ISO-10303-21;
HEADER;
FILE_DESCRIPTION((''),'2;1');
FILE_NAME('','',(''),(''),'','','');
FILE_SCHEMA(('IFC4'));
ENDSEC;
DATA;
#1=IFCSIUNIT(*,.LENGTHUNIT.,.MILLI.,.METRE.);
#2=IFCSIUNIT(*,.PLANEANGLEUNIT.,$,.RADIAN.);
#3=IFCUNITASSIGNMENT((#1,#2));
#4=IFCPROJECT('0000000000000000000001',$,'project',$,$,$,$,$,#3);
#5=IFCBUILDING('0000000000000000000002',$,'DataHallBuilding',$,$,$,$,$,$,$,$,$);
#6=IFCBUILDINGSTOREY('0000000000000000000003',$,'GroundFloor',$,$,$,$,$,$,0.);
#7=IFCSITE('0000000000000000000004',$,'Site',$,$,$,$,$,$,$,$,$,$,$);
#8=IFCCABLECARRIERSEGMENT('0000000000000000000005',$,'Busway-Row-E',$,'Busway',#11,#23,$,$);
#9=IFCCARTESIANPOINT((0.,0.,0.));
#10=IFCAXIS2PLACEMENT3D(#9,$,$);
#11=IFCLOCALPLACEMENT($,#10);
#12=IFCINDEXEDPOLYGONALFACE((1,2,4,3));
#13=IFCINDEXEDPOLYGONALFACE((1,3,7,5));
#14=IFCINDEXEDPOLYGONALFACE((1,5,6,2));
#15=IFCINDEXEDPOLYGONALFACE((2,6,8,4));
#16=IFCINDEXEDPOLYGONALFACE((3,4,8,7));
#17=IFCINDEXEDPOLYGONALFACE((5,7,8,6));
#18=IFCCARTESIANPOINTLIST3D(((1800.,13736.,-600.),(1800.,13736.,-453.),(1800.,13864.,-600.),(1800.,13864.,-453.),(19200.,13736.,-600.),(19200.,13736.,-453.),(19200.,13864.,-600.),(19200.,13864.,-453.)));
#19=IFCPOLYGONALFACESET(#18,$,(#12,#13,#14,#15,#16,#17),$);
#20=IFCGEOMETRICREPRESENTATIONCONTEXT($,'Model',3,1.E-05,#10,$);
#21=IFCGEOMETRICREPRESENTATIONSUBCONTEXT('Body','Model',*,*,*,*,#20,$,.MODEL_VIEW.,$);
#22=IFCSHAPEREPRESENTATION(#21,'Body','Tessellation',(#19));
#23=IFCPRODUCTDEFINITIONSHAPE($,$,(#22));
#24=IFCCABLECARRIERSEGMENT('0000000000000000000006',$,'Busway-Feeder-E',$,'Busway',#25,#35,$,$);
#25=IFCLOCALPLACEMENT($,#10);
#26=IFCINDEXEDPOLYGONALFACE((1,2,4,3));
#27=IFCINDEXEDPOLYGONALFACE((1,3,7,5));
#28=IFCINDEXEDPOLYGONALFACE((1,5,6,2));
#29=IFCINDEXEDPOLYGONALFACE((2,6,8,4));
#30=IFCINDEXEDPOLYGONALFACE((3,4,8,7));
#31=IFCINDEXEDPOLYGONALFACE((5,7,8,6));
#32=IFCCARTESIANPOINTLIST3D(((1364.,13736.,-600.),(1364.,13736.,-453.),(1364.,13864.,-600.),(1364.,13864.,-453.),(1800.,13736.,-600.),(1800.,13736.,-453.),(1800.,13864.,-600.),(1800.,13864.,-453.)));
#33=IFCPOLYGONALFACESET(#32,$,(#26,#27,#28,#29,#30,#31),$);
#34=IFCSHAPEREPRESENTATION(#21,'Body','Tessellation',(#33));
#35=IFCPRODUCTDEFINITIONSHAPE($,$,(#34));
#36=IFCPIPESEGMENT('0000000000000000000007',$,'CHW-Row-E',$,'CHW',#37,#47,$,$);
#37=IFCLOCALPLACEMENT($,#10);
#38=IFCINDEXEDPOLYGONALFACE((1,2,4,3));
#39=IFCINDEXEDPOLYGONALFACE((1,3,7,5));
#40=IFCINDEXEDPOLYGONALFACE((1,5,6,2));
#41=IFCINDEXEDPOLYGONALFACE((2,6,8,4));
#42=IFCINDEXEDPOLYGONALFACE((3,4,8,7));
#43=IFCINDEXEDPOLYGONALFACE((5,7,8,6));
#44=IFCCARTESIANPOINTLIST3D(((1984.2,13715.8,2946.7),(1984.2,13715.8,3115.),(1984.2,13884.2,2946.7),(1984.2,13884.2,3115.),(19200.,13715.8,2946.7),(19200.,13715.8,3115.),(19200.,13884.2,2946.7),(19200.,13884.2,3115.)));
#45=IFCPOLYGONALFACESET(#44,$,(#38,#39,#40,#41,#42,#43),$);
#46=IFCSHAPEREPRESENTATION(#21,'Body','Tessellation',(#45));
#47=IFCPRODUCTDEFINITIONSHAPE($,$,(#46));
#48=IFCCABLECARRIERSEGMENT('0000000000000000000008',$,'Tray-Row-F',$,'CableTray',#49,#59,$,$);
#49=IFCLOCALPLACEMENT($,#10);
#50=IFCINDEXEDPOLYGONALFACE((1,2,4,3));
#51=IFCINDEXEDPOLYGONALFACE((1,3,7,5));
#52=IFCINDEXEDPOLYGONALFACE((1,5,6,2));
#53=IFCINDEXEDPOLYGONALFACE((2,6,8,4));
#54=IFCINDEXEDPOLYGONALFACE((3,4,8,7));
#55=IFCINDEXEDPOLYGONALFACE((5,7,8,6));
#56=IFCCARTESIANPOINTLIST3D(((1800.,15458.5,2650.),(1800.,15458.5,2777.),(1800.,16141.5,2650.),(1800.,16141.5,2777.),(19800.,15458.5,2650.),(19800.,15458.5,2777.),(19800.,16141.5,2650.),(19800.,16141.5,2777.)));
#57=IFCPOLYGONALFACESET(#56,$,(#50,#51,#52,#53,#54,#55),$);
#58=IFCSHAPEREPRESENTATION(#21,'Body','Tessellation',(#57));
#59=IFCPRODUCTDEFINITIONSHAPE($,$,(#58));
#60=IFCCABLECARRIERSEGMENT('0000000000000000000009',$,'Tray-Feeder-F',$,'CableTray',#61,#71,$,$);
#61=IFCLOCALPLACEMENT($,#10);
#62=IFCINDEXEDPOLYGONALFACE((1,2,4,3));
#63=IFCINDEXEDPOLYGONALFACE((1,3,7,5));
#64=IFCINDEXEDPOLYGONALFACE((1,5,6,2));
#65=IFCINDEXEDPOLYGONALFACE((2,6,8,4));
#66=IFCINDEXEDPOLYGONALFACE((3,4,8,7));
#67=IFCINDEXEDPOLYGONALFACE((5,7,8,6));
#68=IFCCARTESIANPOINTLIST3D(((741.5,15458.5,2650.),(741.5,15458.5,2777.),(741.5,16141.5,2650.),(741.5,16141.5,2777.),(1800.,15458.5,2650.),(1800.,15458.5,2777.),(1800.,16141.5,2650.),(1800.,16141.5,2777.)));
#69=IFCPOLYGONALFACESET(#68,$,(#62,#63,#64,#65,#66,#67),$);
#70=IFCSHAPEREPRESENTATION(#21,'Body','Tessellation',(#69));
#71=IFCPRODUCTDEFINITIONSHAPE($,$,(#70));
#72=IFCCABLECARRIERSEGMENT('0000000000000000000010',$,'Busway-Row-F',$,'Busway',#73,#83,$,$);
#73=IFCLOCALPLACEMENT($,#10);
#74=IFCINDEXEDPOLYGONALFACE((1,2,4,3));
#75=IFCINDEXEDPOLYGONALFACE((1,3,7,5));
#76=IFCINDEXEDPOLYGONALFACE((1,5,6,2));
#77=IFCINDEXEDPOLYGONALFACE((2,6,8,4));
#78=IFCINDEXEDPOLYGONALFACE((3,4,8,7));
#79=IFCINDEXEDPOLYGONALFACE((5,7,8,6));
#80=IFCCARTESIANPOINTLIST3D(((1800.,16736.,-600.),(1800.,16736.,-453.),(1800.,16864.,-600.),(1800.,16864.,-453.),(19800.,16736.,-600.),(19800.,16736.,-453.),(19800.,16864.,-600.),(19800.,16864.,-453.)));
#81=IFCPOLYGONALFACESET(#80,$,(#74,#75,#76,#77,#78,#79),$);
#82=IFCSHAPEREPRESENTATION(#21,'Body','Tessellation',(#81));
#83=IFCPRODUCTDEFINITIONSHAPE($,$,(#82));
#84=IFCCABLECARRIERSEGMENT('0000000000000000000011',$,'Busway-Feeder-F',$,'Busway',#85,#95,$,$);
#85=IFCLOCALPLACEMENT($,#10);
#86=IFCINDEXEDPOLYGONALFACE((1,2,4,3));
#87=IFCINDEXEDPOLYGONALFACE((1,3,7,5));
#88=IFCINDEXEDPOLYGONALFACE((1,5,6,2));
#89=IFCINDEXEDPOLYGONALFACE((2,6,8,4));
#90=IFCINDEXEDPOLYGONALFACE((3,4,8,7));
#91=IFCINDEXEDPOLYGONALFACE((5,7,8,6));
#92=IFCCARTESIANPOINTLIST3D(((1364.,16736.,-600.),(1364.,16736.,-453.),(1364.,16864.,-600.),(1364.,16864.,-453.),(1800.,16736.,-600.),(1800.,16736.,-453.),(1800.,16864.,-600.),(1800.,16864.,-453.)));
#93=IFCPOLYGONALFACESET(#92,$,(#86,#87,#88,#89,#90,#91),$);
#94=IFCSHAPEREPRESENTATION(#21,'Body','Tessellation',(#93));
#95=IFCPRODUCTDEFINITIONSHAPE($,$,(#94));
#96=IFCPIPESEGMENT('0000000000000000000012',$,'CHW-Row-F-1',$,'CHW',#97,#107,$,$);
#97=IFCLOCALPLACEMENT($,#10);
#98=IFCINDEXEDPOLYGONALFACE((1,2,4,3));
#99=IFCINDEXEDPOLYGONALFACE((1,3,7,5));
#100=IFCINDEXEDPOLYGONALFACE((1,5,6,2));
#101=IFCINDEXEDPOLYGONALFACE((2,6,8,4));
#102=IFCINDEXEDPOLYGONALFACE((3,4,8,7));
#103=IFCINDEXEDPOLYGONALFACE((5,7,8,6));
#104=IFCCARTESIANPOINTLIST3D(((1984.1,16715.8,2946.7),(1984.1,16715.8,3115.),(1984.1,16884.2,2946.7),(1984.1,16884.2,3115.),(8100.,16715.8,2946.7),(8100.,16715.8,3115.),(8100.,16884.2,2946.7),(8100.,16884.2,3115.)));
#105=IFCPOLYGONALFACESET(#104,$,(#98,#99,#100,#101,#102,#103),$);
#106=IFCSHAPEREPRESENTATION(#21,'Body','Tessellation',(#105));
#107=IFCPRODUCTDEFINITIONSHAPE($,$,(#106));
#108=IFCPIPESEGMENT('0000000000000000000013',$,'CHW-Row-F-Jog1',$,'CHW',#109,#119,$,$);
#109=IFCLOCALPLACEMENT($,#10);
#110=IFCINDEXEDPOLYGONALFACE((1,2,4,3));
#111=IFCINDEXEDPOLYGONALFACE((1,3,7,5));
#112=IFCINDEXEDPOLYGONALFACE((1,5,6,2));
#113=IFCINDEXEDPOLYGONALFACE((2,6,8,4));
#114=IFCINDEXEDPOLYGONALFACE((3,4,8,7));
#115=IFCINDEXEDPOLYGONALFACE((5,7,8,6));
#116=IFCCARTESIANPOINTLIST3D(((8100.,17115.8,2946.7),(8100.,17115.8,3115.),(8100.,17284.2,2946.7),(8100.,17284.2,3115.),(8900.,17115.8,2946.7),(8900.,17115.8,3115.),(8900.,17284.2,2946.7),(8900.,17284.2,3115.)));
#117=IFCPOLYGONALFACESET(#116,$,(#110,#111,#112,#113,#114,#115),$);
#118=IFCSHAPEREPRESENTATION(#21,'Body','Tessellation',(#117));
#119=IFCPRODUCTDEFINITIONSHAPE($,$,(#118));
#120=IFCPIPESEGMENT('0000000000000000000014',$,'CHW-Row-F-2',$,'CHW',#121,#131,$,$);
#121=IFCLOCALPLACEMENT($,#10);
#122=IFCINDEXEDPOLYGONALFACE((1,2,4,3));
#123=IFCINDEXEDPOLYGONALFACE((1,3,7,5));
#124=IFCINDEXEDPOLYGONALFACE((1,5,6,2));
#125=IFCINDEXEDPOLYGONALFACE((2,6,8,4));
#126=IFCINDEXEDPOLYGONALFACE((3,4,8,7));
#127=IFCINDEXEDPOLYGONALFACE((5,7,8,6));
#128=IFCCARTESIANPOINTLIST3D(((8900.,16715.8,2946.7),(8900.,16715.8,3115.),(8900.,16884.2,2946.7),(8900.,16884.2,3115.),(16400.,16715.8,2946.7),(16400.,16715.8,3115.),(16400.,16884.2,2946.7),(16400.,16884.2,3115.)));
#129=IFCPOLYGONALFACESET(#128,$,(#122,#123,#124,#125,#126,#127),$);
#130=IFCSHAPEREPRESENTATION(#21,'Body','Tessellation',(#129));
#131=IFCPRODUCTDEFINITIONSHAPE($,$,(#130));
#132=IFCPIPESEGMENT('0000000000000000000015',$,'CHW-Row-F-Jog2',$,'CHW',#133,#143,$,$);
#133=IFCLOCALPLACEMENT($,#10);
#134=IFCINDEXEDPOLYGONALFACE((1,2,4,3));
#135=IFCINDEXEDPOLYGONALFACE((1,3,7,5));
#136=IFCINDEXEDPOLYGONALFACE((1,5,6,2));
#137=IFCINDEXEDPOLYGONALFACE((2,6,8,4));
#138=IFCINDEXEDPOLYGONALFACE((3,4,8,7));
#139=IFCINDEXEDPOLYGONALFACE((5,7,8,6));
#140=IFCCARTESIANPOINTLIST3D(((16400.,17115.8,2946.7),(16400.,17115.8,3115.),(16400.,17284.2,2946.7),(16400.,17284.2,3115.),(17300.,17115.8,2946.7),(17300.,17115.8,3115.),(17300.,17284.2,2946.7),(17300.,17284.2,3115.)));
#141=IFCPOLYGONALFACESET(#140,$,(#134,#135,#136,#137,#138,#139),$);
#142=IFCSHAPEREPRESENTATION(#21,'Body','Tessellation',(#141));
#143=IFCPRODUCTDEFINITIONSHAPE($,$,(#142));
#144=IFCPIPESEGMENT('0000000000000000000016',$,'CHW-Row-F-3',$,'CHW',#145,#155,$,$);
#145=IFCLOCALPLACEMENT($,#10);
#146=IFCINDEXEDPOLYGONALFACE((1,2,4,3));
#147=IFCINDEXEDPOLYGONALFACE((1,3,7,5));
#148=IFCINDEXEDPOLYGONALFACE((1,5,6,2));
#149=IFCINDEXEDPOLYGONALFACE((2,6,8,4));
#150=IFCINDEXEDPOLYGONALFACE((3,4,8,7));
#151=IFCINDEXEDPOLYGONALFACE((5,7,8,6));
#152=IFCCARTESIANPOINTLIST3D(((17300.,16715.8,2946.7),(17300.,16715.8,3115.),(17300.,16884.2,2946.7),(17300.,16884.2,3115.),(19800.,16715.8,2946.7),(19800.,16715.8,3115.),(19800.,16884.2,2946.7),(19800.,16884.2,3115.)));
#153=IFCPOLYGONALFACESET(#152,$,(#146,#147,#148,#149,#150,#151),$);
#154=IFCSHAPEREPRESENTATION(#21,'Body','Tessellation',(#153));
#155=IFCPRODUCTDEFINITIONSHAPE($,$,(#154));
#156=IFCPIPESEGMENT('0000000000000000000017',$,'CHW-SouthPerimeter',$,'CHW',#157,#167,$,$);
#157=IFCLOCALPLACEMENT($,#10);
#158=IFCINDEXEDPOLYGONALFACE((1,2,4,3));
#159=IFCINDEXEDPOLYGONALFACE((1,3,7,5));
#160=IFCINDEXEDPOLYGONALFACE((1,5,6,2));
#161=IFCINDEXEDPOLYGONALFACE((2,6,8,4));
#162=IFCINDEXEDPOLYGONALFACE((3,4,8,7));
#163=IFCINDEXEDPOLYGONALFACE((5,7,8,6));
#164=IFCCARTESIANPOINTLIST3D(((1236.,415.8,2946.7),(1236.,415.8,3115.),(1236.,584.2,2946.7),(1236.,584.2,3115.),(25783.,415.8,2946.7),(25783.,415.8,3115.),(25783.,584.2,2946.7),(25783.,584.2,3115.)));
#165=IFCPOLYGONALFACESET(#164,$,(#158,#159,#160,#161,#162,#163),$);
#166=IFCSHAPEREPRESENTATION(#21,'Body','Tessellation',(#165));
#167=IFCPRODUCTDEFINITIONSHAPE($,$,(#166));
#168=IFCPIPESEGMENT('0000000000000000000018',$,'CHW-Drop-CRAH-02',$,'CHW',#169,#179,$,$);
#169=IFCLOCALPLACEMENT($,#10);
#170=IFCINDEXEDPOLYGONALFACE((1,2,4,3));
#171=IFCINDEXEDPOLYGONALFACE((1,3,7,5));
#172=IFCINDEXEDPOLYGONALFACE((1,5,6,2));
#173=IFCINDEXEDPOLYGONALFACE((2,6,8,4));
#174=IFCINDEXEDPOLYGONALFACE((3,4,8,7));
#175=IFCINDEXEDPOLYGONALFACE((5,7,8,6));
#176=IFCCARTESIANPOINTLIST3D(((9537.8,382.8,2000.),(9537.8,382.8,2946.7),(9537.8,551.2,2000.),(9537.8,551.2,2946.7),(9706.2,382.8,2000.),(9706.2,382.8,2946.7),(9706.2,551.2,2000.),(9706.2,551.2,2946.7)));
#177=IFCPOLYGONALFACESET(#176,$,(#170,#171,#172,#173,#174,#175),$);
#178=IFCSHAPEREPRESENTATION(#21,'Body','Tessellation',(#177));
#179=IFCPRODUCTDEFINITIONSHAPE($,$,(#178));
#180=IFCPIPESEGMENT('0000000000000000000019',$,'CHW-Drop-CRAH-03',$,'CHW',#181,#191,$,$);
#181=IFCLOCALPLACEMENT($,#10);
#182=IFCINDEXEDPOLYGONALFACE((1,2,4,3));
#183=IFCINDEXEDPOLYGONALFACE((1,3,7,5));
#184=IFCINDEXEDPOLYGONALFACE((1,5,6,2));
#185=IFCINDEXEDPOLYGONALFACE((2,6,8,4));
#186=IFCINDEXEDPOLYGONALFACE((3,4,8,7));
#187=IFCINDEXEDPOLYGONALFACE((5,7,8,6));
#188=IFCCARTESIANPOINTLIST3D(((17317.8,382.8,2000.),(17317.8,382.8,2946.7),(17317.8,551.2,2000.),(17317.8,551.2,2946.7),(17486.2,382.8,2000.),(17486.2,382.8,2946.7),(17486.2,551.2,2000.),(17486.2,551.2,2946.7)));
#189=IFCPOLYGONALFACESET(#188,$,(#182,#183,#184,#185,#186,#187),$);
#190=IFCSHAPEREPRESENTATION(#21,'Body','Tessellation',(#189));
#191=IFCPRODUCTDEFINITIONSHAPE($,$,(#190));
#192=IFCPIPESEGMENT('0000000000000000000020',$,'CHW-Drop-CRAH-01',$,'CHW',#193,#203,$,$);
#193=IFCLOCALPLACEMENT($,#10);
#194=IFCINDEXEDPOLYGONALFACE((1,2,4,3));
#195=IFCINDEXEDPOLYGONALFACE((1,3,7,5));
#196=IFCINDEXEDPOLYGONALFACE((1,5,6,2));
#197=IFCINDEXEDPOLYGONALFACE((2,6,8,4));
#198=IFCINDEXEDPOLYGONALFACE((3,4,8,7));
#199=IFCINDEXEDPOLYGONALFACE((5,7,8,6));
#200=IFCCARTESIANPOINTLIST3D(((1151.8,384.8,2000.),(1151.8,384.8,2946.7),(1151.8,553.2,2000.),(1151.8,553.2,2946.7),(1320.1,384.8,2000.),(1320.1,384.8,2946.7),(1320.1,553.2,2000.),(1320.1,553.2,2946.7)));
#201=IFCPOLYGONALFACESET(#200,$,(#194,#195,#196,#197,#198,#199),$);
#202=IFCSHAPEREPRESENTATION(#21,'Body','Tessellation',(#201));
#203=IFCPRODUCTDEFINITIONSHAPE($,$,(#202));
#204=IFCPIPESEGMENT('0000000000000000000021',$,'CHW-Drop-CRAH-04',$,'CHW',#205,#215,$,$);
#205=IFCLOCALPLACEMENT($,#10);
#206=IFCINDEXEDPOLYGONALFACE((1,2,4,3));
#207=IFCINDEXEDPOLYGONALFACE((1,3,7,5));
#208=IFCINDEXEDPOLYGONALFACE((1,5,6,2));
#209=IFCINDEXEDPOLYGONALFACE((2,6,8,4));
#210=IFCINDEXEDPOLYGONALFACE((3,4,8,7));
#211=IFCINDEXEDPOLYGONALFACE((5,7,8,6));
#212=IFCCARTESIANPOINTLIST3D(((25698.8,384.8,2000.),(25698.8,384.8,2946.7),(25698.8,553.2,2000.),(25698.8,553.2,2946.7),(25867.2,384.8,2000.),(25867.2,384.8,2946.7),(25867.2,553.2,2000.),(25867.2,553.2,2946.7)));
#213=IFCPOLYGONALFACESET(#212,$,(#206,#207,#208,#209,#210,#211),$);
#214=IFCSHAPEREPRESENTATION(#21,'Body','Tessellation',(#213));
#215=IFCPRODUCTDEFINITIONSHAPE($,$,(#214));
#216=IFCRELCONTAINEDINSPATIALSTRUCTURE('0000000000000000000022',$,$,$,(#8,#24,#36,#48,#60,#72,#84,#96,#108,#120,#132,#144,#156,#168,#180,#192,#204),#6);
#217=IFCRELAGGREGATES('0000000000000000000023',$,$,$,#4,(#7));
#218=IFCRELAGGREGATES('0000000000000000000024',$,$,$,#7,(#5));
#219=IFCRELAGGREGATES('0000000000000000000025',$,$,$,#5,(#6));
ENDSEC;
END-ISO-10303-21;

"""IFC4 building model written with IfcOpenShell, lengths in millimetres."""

from ifc_helpers import new_model, si_unit, frame, origin, place, context, subcontext, project, spatial, rectangle, extrude, element, save


model = new_model("IFC4")

# Units and contexts
model_context = context("Model", 3, precision=1e-05, world=origin())
body_context = subcontext(model_context, "Body", "Model", "MODEL_VIEW")
ifc_project = project(units=[si_unit("LENGTHUNIT", "METRE", prefix="MILLI"), si_unit("PLANEANGLEUNIT", "RADIAN")])

# Site, building, storey
site = spatial("IfcSite", under=ifc_project, Name="Site")
building = spatial("IfcBuilding", under=site, Name="DataHallBuilding")
storey = spatial("IfcBuildingStorey", under=building, Name="GroundFloor", Elevation=0.0)

# Cable carrier segments
cable_carrier_segment_1_placement = place(None, origin())
element("IfcCableCarrierSegment", 1, at=cable_carrier_segment_1_placement, inside=storey, Name="Busway-Row-E", ObjectType="Busway", context=body_context, shape_type="SweptSolid", body=[
    extrude(rectangle(XDim=17400.0, YDim=128.0), frame((10500.0, 13800.0, -600.0), z_axis=(0.0, 0.0, 1.0), x_axis=(1.0, 0.0, 0.0)), (0.0, 0.0, 1.0), 147.0),
])
cable_carrier_segment_2_placement = place(None, origin())
element("IfcCableCarrierSegment", 2, at=cable_carrier_segment_2_placement, inside=storey, Name="Busway-Feeder-E", ObjectType="Busway", context=body_context, shape_type="SweptSolid", body=[
    extrude(rectangle(XDim=436.0, YDim=128.0), frame((1582.0, 13800.0, -600.0), z_axis=(0.0, 0.0, 1.0), x_axis=(1.0, 0.0, 0.0)), (0.0, 0.0, 1.0), 147.0),
])

# Pipe segment
pipe_segment_1_placement = place(None, origin())
element("IfcPipeSegment", 3, at=pipe_segment_1_placement, inside=storey, Name="CHW-Row-E", ObjectType="CHW", context=body_context, shape_type="SweptSolid", body=[
    extrude(rectangle(XDim=17215.8, YDim=168.3), frame((10592.1, 13800.0, 2946.7), z_axis=(0.0, 0.0, 1.0), x_axis=(1.0, 0.0, 0.0)), (0.0, 0.0, 1.0), 168.3),
])

# Cable carrier segments
cable_carrier_segment_3_placement = place(None, origin())
element("IfcCableCarrierSegment", 4, at=cable_carrier_segment_3_placement, inside=storey, Name="Tray-Row-F", ObjectType="CableTray", context=body_context, shape_type="SweptSolid", body=[
    extrude(rectangle(XDim=18000.0, YDim=683.0), frame((10800.0, 15800.0, 2650.0), z_axis=(0.0, 0.0, 1.0), x_axis=(1.0, 0.0, 0.0)), (0.0, 0.0, 1.0), 127.0),
])
cable_carrier_segment_4_placement = place(None, origin())
element("IfcCableCarrierSegment", 5, at=cable_carrier_segment_4_placement, inside=storey, Name="Tray-Feeder-F", ObjectType="CableTray", context=body_context, shape_type="SweptSolid", body=[
    extrude(rectangle(XDim=1058.5, YDim=683.0), frame((1270.8, 15800.0, 2650.0), z_axis=(0.0, 0.0, 1.0), x_axis=(1.0, 0.0, 0.0)), (0.0, 0.0, 1.0), 127.0),
])
cable_carrier_segment_5_placement = place(None, origin())
element("IfcCableCarrierSegment", 6, at=cable_carrier_segment_5_placement, inside=storey, Name="Busway-Row-F", ObjectType="Busway", context=body_context, shape_type="SweptSolid", body=[
    extrude(rectangle(XDim=18000.0, YDim=128.0), frame((10800.0, 16800.0, -600.0), z_axis=(0.0, 0.0, 1.0), x_axis=(1.0, 0.0, 0.0)), (0.0, 0.0, 1.0), 147.0),
])
cable_carrier_segment_6_placement = place(None, origin())
element("IfcCableCarrierSegment", 7, at=cable_carrier_segment_6_placement, inside=storey, Name="Busway-Feeder-F", ObjectType="Busway", context=body_context, shape_type="SweptSolid", body=[
    extrude(rectangle(XDim=436.0, YDim=128.0), frame((1582.0, 16800.0, -600.0), z_axis=(0.0, 0.0, 1.0), x_axis=(1.0, 0.0, 0.0)), (0.0, 0.0, 1.0), 147.0),
])

# Pipe segments
pipe_segment_2_placement = place(None, origin())
element("IfcPipeSegment", 8, at=pipe_segment_2_placement, inside=storey, Name="CHW-Row-F-1", ObjectType="CHW", context=body_context, shape_type="SweptSolid", body=[
    extrude(rectangle(XDim=6115.9, YDim=168.3), frame((5042.1, 16800.0, 2946.7), z_axis=(0.0, 0.0, 1.0), x_axis=(1.0, 0.0, 0.0)), (0.0, 0.0, 1.0), 168.3),
])
pipe_segment_3_placement = place(None, origin())
element("IfcPipeSegment", 9, at=pipe_segment_3_placement, inside=storey, Name="CHW-Row-F-Jog1", ObjectType="CHW", context=body_context, shape_type="SweptSolid", body=[
    extrude(rectangle(XDim=800.0, YDim=168.3), frame((8500.0, 17200.0, 2946.7), z_axis=(0.0, 0.0, 1.0), x_axis=(1.0, 0.0, 0.0)), (0.0, 0.0, 1.0), 168.3),
])
pipe_segment_4_placement = place(None, origin())
element("IfcPipeSegment", 10, at=pipe_segment_4_placement, inside=storey, Name="CHW-Row-F-2", ObjectType="CHW", context=body_context, shape_type="SweptSolid", body=[
    extrude(rectangle(XDim=7500.0, YDim=168.3), frame((12650.0, 16800.0, 2946.7), z_axis=(0.0, 0.0, 1.0), x_axis=(1.0, 0.0, 0.0)), (0.0, 0.0, 1.0), 168.3),
])
pipe_segment_5_placement = place(None, origin())
element("IfcPipeSegment", 11, at=pipe_segment_5_placement, inside=storey, Name="CHW-Row-F-Jog2", ObjectType="CHW", context=body_context, shape_type="SweptSolid", body=[
    extrude(rectangle(XDim=900.0, YDim=168.3), frame((16850.0, 17200.0, 2946.7), z_axis=(0.0, 0.0, 1.0), x_axis=(1.0, 0.0, 0.0)), (0.0, 0.0, 1.0), 168.3),
])
pipe_segment_6_placement = place(None, origin())
element("IfcPipeSegment", 12, at=pipe_segment_6_placement, inside=storey, Name="CHW-Row-F-3", ObjectType="CHW", context=body_context, shape_type="SweptSolid", body=[
    extrude(rectangle(XDim=2500.0, YDim=168.3), frame((18550.0, 16800.0, 2946.7), z_axis=(0.0, 0.0, 1.0), x_axis=(1.0, 0.0, 0.0)), (0.0, 0.0, 1.0), 168.3),
])
pipe_segment_7_placement = place(None, origin())
element("IfcPipeSegment", 13, at=pipe_segment_7_placement, inside=storey, Name="CHW-SouthPerimeter", ObjectType="CHW", context=body_context, shape_type="SweptSolid", body=[
    extrude(rectangle(XDim=24547.0, YDim=168.3), frame((13509.5, 500.0, 2946.7), z_axis=(0.0, 0.0, 1.0), x_axis=(1.0, 0.0, 0.0)), (0.0, 0.0, 1.0), 168.3),
])
pipe_segment_8_placement = place(None, origin())
element("IfcPipeSegment", 14, at=pipe_segment_8_placement, inside=storey, Name="CHW-Drop-CRAH-02", ObjectType="CHW", context=body_context, shape_type="SweptSolid", body=[
    extrude(rectangle(XDim=168.3, YDim=168.3), frame((9622.0, 467.0, 2000.0), z_axis=(0.0, 0.0, 1.0), x_axis=(1.0, 0.0, 0.0)), (0.0, 0.0, 1.0), 946.7),
])
pipe_segment_9_placement = place(None, origin())
element("IfcPipeSegment", 15, at=pipe_segment_9_placement, inside=storey, Name="CHW-Drop-CRAH-03", ObjectType="CHW", context=body_context, shape_type="SweptSolid", body=[
    extrude(rectangle(XDim=168.3, YDim=168.3), frame((17402.0, 467.0, 2000.0), z_axis=(0.0, 0.0, 1.0), x_axis=(1.0, 0.0, 0.0)), (0.0, 0.0, 1.0), 946.7),
])
pipe_segment_10_placement = place(None, origin())
element("IfcPipeSegment", 16, at=pipe_segment_10_placement, inside=storey, Name="CHW-Drop-CRAH-01", ObjectType="CHW", context=body_context, shape_type="SweptSolid", body=[
    extrude(rectangle(XDim=168.3, YDim=168.3), frame((1236.0, 469.0, 2000.0), z_axis=(0.0, 0.0, 1.0), x_axis=(1.0, 0.0, 0.0)), (0.0, 0.0, 1.0), 946.7),
])
pipe_segment_11_placement = place(None, origin())
element("IfcPipeSegment", 17, at=pipe_segment_11_placement, inside=storey, Name="CHW-Drop-CRAH-04", ObjectType="CHW", context=body_context, shape_type="SweptSolid", body=[
    extrude(rectangle(XDim=168.3, YDim=168.3), frame((25783.0, 469.0, 2000.0), z_axis=(0.0, 0.0, 1.0), x_axis=(1.0, 0.0, 0.0)), (0.0, 0.0, 1.0), 946.7),
])

save(model, "model.ifc")
